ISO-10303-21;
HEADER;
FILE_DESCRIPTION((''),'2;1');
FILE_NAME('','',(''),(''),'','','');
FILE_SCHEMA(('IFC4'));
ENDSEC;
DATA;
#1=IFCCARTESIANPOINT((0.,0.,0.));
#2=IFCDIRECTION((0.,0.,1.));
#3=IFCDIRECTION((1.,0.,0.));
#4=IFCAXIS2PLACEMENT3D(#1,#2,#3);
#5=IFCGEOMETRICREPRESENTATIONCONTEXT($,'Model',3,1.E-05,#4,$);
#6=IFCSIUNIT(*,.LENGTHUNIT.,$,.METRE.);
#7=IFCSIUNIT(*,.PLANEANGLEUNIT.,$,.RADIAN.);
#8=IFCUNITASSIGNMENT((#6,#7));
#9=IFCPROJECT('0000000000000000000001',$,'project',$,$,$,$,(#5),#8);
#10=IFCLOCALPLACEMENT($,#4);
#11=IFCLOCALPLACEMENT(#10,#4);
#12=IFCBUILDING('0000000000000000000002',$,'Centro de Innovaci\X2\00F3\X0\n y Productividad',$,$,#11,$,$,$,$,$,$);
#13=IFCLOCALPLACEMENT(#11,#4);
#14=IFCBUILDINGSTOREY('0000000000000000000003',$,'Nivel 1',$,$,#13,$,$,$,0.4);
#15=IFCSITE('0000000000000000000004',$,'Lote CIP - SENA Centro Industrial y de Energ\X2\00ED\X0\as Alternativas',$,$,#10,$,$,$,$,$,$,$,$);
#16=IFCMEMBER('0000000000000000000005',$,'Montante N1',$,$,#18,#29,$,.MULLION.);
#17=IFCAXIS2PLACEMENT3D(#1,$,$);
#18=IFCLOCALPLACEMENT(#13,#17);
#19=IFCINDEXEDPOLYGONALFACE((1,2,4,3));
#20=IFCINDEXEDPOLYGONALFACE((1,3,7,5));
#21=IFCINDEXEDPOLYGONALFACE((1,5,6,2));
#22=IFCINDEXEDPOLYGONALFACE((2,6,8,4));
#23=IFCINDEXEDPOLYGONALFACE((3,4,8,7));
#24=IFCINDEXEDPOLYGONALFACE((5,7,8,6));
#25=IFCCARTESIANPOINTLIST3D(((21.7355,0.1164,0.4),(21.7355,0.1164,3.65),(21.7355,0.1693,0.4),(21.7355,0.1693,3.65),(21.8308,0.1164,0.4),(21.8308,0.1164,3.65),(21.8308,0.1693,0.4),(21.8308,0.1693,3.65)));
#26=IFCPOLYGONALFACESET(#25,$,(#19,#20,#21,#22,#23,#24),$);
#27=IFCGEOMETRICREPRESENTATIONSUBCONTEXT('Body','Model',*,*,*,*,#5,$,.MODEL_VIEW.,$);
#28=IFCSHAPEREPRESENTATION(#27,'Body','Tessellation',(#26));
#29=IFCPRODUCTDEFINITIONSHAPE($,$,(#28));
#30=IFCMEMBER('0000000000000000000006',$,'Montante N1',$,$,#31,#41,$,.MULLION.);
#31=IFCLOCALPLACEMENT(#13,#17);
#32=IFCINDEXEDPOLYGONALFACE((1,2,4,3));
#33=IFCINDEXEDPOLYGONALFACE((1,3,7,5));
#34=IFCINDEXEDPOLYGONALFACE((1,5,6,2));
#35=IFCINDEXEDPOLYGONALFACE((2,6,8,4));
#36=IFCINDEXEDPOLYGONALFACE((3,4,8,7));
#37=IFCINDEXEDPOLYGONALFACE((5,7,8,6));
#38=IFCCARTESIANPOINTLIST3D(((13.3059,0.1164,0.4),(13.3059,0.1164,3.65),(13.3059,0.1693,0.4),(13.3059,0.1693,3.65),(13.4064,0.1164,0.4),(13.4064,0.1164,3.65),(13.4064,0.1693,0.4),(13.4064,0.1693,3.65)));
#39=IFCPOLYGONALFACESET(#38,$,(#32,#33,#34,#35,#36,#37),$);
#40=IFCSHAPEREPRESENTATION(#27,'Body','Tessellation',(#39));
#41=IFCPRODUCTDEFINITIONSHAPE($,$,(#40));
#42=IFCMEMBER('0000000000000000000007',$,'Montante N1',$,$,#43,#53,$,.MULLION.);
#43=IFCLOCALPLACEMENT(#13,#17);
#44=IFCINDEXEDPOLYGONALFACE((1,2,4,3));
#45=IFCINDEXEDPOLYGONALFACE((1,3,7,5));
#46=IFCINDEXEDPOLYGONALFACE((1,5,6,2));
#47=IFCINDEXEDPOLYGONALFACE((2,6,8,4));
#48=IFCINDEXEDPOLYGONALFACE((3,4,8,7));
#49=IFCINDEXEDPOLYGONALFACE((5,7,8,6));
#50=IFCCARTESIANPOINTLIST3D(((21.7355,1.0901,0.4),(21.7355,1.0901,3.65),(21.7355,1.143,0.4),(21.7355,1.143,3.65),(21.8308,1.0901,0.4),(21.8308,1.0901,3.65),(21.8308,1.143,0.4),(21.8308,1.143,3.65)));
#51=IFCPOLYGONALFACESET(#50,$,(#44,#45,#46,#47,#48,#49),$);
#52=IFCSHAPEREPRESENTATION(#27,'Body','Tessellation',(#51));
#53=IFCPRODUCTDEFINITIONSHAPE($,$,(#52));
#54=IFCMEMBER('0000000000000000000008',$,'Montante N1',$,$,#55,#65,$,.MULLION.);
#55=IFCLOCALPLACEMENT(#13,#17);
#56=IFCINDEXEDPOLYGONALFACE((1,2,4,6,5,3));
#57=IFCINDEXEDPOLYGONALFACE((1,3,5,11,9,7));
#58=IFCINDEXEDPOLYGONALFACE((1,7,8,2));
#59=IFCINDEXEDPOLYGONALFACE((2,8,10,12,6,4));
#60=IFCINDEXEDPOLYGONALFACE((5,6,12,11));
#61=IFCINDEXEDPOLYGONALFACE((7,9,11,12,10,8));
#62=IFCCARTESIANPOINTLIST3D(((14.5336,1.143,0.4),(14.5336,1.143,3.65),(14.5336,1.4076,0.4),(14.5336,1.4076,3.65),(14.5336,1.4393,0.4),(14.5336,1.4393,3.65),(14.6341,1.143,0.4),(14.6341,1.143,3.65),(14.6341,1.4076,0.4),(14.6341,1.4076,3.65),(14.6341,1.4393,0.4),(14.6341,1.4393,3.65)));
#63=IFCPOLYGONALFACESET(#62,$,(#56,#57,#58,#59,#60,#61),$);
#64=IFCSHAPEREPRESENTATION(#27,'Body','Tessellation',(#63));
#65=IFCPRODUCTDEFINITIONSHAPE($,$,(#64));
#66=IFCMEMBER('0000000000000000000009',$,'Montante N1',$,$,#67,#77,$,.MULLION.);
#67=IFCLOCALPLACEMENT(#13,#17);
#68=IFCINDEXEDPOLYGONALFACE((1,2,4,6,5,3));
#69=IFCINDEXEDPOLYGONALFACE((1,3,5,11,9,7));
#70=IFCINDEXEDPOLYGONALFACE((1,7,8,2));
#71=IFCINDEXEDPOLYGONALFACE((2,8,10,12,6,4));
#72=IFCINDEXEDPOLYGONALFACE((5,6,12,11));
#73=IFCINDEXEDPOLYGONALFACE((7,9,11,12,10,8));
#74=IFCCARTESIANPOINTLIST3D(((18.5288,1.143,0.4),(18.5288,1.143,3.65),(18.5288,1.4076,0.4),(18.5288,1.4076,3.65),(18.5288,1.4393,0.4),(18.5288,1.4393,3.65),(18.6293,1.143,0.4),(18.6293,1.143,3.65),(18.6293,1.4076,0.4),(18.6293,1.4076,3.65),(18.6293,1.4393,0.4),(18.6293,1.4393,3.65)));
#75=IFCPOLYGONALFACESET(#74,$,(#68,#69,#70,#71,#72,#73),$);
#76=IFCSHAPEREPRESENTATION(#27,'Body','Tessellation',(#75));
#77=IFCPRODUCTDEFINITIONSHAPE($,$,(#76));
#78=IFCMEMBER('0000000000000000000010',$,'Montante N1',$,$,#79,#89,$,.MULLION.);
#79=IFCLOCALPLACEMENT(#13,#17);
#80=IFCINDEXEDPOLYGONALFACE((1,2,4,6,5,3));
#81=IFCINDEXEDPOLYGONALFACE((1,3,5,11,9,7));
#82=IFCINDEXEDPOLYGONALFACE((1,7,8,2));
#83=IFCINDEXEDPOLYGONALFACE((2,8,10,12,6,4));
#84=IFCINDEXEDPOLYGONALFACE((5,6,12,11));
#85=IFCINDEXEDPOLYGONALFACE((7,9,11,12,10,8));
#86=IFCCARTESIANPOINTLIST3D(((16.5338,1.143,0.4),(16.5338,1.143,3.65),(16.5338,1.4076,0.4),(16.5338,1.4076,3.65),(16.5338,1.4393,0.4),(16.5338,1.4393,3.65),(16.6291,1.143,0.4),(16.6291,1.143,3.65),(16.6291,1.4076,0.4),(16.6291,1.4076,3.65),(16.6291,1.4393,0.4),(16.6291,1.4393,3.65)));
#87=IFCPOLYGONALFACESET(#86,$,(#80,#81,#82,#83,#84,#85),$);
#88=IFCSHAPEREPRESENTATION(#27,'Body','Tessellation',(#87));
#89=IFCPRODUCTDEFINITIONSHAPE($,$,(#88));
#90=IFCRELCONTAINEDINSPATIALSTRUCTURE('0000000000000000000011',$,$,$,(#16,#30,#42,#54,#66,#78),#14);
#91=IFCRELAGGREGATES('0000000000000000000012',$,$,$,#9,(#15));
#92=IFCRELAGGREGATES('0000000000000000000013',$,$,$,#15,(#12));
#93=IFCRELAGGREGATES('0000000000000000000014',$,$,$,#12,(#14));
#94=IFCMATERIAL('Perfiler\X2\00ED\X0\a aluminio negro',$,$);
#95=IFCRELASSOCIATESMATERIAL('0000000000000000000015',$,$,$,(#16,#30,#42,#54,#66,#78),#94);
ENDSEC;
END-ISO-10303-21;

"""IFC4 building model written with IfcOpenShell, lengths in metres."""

from ifc_helpers import new_model, si_unit, frame, origin_with_axes, place, context, subcontext, project, spatial, polyline, outline, extrude, material, element, save


model = new_model("IFC4")

# Units and contexts
model_context = context("Model", 3, precision=1e-05, world=origin_with_axes())
body_context = subcontext(model_context, "Body", "Model", "MODEL_VIEW")
ifc_project = project(units=[si_unit("LENGTHUNIT", "METRE"), si_unit("PLANEANGLEUNIT", "RADIAN")], contexts=[model_context])

# Site, building, storey
site_placement = place(None, origin_with_axes())
site = spatial("IfcSite", under=ifc_project, at=site_placement, Name="Lote CIP - SENA Centro Industrial y de Energías Alternativas")
building_placement = place(site_placement, origin_with_axes())
building = spatial("IfcBuilding", under=site, at=building_placement, Name="Centro de Innovación y Productividad")
storey_placement = place(building_placement, origin_with_axes())
storey = spatial("IfcBuildingStorey", under=building, at=storey_placement, Name="Nivel 1", Elevation=0.4)

# Members
ifc_material = material(Name="Perfilería aluminio negro")
member_1_placement = place(storey_placement, origin_with_axes())
element("IfcMember", 1, at=member_1_placement, inside=storey, material=ifc_material, Name="Montante N1", PredefinedType="MULLION", context=body_context, shape_type="SweptSolid", body=[
    extrude(outline(polyline([(21.7355, 0.1164), (21.7355, 0.1693), (21.8308, 0.1693), (21.8308, 0.1164), (21.7355, 0.1164)])), frame((0.0, 0.0, 0.4)), (0.0, 0.0, 1.0), 3.25),
])
member_2_placement = place(storey_placement, origin_with_axes())
element("IfcMember", 2, at=member_2_placement, inside=storey, material=ifc_material, Name="Montante N1", PredefinedType="MULLION", context=body_context, shape_type="SweptSolid", body=[
    extrude(outline(polyline([(13.4064, 0.1164), (13.3059, 0.1164), (13.3059, 0.1693), (13.4064, 0.1693), (13.4064, 0.1164)])), frame((0.0, 0.0, 0.4)), (0.0, 0.0, 1.0), 3.25),
])
member_3_placement = place(storey_placement, origin_with_axes())
element("IfcMember", 3, at=member_3_placement, inside=storey, material=ifc_material, Name="Montante N1", PredefinedType="MULLION", context=body_context, shape_type="SweptSolid", body=[
    extrude(outline(polyline([(21.7355, 1.143), (21.8308, 1.143), (21.8308, 1.0901), (21.7355, 1.0901), (21.7355, 1.143)])), frame((0.0, 0.0, 0.4)), (0.0, 0.0, 1.0), 3.25),
])
member_4_placement = place(storey_placement, origin_with_axes())
element("IfcMember", 4, at=member_4_placement, inside=storey, material=ifc_material, Name="Montante N1", PredefinedType="MULLION", context=body_context, shape_type="SweptSolid", body=[
    extrude(outline(polyline([(14.5336, 1.143), (14.5336, 1.4076), (14.5336, 1.4393), (14.6341, 1.4393), (14.6341, 1.4076), (14.6341, 1.143), (14.5336, 1.143)])), frame((0.0, 0.0, 0.4)), (0.0, 0.0, 1.0), 3.25),
])
member_5_placement = place(storey_placement, origin_with_axes())
element("IfcMember", 5, at=member_5_placement, inside=storey, material=ifc_material, Name="Montante N1", PredefinedType="MULLION", context=body_context, shape_type="SweptSolid", body=[
    extrude(outline(polyline([(18.6293, 1.4076), (18.6293, 1.143), (18.5288, 1.143), (18.5288, 1.4076), (18.5288, 1.4393), (18.6293, 1.4393), (18.6293, 1.4076)])), frame((0.0, 0.0, 0.4)), (0.0, 0.0, 1.0), 3.25),
])
member_6_placement = place(storey_placement, origin_with_axes())
element("IfcMember", 6, at=member_6_placement, inside=storey, material=ifc_material, Name="Montante N1", PredefinedType="MULLION", context=body_context, shape_type="SweptSolid", body=[
    extrude(outline(polyline([(16.6291, 1.4076), (16.6291, 1.143), (16.5338, 1.143), (16.5338, 1.4076), (16.5338, 1.4393), (16.6291, 1.4393), (16.6291, 1.4076)])), frame((0.0, 0.0, 0.4)), (0.0, 0.0, 1.0), 3.25),
])

save(model, "model.ifc")
